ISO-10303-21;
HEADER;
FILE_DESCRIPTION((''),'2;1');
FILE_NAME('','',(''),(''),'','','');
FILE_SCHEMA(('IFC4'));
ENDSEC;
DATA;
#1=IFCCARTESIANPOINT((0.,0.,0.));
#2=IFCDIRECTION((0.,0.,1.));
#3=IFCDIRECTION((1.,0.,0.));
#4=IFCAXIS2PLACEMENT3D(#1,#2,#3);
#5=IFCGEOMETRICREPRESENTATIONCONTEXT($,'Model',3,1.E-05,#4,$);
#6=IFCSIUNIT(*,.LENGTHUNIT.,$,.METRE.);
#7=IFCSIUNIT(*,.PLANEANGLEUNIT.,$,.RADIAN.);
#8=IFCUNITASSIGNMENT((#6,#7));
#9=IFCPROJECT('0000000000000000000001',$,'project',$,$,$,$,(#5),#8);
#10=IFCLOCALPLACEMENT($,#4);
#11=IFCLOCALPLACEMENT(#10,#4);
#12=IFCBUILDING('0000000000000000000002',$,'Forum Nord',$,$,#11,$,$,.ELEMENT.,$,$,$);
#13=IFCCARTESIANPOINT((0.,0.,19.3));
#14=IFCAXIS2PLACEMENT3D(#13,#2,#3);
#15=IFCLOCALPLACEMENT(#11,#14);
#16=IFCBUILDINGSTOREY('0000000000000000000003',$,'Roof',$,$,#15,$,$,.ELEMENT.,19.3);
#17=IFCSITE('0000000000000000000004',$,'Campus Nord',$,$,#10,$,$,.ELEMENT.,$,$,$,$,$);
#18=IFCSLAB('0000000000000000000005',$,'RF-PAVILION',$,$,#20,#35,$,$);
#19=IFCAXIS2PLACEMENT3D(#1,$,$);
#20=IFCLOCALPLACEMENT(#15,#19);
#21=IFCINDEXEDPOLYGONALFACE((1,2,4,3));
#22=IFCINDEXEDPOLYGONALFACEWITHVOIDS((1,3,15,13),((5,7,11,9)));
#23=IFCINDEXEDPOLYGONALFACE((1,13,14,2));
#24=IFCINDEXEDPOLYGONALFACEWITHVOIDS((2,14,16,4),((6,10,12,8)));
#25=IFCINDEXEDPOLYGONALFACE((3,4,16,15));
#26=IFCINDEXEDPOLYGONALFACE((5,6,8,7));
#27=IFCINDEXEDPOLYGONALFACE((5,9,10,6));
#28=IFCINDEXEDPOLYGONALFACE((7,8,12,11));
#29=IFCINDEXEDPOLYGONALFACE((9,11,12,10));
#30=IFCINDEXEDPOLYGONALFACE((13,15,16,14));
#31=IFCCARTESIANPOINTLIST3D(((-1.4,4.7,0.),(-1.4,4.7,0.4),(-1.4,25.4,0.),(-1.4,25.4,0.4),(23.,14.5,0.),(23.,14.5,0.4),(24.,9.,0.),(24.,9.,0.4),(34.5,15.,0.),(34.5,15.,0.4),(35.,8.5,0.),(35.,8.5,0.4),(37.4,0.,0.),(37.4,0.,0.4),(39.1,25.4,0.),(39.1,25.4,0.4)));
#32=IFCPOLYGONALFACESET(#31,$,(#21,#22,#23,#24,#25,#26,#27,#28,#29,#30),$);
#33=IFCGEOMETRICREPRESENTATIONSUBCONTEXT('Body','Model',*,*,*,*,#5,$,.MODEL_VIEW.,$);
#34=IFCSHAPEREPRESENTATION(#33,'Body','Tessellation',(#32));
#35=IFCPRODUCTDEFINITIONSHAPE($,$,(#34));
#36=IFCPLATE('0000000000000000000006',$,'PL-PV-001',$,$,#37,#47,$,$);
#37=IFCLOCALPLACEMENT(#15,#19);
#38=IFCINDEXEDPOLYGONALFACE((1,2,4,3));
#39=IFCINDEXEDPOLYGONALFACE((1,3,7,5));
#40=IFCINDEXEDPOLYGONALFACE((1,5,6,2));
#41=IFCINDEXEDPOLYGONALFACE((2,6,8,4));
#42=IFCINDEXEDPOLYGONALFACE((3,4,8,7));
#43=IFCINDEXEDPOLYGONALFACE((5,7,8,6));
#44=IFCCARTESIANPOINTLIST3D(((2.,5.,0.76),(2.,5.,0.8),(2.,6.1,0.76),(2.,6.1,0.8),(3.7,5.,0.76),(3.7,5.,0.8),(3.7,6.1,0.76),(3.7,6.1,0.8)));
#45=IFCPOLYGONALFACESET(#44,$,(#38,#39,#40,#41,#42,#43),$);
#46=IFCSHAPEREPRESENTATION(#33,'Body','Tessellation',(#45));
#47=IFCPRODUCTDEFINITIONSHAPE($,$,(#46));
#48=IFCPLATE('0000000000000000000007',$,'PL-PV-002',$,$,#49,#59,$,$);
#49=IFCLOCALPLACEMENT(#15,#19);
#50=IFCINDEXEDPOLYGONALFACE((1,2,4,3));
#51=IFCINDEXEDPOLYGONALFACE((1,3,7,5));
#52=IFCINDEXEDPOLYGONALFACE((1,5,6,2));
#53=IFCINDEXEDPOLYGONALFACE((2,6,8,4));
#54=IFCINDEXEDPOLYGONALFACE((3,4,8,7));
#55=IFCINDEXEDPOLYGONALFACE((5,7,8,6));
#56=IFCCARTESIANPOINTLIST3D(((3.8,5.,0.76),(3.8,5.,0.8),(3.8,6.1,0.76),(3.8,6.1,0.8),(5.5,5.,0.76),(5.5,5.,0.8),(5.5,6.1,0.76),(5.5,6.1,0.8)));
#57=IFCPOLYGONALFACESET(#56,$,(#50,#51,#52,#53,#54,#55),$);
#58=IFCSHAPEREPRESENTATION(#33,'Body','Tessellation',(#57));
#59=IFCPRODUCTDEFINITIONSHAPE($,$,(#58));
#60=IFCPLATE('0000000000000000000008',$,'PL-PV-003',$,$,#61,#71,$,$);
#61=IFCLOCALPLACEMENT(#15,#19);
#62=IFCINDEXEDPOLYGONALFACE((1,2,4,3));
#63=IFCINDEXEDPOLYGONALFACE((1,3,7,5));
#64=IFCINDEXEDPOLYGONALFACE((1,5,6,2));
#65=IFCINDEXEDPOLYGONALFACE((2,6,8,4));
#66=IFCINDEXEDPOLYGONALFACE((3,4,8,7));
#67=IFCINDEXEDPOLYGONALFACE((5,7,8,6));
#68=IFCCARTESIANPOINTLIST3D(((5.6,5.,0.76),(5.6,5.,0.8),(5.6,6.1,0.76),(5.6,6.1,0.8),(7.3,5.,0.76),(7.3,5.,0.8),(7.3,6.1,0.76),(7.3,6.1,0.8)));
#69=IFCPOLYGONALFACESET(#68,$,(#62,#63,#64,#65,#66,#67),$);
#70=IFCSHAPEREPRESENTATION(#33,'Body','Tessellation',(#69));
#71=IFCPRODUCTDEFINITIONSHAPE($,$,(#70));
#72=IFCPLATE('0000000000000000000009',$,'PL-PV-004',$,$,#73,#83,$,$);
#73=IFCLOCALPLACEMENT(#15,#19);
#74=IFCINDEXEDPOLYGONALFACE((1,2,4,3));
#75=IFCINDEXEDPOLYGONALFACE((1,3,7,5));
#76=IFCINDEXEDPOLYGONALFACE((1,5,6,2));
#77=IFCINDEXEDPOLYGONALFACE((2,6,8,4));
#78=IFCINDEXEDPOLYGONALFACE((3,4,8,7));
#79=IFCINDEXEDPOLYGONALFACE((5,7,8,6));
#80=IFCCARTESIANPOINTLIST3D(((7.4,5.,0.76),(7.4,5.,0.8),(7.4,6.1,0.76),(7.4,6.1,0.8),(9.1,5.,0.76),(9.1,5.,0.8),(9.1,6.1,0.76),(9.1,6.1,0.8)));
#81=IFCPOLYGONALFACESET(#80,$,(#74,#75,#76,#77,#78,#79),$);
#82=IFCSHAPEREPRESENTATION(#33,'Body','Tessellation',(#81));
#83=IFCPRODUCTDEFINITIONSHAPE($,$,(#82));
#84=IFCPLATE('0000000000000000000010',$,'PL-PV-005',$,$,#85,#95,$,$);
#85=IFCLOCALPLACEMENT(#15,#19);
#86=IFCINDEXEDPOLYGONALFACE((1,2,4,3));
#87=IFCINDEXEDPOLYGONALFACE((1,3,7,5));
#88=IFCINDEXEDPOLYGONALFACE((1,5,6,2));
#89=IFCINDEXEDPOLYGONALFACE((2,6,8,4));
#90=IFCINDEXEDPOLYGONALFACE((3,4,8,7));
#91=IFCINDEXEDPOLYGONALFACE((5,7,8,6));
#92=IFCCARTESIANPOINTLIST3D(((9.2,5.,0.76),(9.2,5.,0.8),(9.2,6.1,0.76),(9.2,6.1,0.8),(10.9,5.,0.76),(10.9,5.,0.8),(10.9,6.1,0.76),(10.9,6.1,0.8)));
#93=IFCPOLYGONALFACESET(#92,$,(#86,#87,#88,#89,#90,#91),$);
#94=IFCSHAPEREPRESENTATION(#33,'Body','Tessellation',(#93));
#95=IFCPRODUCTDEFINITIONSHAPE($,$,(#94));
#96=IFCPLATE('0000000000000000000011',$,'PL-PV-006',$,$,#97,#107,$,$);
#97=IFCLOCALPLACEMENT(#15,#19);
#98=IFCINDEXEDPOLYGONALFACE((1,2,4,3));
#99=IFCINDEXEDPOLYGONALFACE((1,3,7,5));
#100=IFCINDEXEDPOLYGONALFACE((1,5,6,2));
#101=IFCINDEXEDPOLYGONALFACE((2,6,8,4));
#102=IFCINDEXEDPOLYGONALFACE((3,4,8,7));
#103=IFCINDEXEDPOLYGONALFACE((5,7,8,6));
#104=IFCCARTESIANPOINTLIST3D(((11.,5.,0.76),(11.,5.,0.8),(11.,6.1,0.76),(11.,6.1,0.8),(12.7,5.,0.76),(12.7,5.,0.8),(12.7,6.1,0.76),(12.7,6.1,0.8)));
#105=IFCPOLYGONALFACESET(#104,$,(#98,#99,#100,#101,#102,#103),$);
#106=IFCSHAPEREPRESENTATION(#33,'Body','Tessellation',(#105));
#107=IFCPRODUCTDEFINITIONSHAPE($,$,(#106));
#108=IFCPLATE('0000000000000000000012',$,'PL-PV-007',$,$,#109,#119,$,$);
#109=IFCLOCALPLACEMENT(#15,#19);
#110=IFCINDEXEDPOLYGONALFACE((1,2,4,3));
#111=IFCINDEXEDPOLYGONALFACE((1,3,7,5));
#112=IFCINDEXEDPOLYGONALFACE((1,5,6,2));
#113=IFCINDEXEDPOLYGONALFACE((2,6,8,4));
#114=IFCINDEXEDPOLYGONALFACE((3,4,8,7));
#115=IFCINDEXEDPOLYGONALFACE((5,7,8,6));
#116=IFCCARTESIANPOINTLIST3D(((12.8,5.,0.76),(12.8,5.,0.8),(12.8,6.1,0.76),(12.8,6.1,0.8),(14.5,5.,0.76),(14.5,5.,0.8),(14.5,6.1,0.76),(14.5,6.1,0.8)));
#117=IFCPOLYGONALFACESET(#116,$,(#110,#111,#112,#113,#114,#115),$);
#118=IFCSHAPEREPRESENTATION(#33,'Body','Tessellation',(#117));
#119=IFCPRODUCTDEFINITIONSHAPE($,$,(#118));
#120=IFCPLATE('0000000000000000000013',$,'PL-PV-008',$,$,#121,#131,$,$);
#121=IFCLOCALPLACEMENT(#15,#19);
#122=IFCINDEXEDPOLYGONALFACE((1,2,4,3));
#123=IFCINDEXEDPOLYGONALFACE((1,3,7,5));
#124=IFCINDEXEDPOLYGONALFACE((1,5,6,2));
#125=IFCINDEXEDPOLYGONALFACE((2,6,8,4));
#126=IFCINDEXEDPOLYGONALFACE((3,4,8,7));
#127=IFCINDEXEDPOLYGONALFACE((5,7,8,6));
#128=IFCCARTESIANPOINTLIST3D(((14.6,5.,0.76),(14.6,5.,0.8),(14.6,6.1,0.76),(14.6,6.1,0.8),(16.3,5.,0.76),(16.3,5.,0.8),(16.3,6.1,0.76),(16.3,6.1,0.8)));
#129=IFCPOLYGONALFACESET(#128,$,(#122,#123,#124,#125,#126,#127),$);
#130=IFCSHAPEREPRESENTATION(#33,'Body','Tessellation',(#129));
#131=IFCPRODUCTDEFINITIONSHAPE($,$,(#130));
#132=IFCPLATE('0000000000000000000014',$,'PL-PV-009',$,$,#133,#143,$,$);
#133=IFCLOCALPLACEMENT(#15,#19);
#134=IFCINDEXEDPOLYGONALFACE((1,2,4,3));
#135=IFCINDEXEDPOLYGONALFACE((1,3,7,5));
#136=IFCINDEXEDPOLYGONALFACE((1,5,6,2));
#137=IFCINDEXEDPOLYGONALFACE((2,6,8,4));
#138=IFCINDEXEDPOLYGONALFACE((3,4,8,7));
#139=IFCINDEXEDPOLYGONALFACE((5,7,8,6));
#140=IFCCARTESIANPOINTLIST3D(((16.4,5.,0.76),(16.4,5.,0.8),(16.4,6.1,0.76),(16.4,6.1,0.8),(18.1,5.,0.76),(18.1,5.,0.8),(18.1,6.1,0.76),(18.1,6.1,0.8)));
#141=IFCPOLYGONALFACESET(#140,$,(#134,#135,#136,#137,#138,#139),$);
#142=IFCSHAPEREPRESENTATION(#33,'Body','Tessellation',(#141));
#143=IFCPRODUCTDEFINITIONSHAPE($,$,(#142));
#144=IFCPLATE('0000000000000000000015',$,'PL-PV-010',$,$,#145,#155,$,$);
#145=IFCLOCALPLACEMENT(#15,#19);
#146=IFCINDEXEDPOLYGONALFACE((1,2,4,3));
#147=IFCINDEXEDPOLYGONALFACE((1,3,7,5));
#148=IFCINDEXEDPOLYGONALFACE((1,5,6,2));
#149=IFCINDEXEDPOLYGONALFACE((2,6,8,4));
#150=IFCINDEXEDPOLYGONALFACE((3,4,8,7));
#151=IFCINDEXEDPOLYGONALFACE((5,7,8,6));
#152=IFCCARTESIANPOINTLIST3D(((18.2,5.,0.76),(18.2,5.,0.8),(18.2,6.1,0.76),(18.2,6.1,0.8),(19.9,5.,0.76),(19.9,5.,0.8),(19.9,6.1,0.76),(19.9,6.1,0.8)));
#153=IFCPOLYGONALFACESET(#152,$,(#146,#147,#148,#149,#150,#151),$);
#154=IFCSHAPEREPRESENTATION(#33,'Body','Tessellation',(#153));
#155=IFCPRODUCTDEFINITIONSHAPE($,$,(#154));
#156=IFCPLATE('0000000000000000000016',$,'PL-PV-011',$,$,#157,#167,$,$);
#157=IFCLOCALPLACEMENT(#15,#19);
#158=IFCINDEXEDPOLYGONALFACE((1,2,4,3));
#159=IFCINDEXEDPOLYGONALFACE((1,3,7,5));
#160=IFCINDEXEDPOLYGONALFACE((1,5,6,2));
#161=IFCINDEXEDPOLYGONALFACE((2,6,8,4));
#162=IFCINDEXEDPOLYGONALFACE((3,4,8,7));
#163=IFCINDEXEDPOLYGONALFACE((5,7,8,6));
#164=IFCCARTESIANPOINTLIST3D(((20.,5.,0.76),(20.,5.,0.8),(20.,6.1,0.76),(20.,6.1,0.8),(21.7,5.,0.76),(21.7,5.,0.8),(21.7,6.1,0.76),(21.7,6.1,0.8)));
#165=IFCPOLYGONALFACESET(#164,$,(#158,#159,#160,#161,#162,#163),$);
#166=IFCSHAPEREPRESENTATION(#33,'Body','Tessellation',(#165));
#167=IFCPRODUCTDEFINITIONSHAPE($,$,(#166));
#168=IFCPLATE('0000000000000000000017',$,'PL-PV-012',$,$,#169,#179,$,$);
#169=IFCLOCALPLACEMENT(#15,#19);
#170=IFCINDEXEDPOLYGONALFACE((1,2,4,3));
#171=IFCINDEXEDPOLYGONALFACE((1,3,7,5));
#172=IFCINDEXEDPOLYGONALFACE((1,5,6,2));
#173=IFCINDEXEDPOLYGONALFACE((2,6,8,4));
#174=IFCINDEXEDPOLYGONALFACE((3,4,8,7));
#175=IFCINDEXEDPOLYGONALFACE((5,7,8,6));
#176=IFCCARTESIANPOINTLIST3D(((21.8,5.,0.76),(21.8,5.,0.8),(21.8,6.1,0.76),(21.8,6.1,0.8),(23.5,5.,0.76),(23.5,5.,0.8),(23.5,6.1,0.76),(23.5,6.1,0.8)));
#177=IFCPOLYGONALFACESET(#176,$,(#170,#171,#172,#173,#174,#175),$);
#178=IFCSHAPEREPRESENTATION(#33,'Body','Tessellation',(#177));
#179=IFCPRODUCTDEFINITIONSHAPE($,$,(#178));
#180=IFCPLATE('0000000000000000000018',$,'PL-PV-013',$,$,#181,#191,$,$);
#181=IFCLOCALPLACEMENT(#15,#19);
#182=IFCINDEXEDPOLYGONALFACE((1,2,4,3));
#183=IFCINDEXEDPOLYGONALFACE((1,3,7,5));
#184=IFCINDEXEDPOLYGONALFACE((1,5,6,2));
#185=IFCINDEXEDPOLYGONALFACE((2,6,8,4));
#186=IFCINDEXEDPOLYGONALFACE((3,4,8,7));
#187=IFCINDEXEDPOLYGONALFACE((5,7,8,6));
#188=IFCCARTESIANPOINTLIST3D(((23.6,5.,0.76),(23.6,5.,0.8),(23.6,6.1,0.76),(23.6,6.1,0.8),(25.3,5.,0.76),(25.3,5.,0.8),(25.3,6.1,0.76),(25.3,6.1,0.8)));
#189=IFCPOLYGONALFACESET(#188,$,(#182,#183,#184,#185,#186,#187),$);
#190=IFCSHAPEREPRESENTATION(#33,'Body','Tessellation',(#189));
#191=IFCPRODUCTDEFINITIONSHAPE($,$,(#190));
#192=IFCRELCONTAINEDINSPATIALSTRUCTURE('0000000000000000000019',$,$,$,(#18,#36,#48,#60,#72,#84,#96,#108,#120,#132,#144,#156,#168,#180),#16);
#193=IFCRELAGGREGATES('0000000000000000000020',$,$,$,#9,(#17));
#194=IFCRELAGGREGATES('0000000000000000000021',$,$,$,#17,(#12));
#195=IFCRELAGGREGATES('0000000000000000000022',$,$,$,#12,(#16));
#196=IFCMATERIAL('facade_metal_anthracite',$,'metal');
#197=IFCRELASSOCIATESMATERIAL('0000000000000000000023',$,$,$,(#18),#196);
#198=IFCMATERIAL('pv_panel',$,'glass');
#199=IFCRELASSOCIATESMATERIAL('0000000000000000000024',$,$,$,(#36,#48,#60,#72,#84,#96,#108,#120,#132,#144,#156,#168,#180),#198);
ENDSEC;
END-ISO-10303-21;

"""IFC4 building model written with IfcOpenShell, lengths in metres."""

from ifc_helpers import new_model, si_unit, frame, origin_with_axes, place, context, subcontext, project, spatial, polyline, outline, extrude, material, element, save


model = new_model("IFC4")

# Units and contexts
model_context = context("Model", 3, precision=1e-05, world=origin_with_axes())
body_context = subcontext(model_context, "Body", "Model", "MODEL_VIEW")
ifc_project = project(units=[si_unit("LENGTHUNIT", "METRE"), si_unit("PLANEANGLEUNIT", "RADIAN")], contexts=[model_context])

# Site, building, storey
site_placement = place(None, origin_with_axes())
site = spatial("IfcSite", under=ifc_project, at=site_placement, Name="Campus Nord", CompositionType="ELEMENT")
building_placement = place(site_placement, origin_with_axes())
building = spatial("IfcBuilding", under=site, at=building_placement, Name="Forum Nord", CompositionType="ELEMENT")
storey_placement = place(building_placement, frame((0.0, 0.0, 19.3), z_axis=(0.0, 0.0, 1.0), x_axis=(1.0, 0.0, 0.0)))
storey = spatial("IfcBuildingStorey", under=building, at=storey_placement, Name="Roof", CompositionType="ELEMENT", Elevation=19.3)

# Slab
ifc_material_1 = material(Name="facade_metal_anthracite", Category="metal")
slab_placement = place(storey_placement, frame((0.0, 0.0, 0.4), z_axis=(0.0, 0.0, 1.0), x_axis=(1.0, 0.0, 0.0)))
element("IfcSlab", 1, at=slab_placement, inside=storey, material=ifc_material_1, Name="RF-PAVILION", context=body_context, shape_type="SweptSolid", body=[
    extrude(outline(polyline([(-1.4, 4.7), (37.4, 0.0), (39.1, 25.4), (-1.4, 25.4), (-1.4, 4.7)]), holes=[polyline([(24.0, 9.0), (35.0, 8.5), (34.5, 15.0), (23.0, 14.5), (24.0, 9.0)])]), frame((0.0, 0.0, -0.4), z_axis=(0.0, 0.0, 1.0), x_axis=(1.0, 0.0, 0.0)), (0.0, 0.0, 1.0), 0.4),
])

# Plates
ifc_material_2 = material(Name="pv_panel", Category="glass")
plate_1_placement = place(storey_placement, frame((0.0, 0.0, 0.8), z_axis=(0.0, 0.0, 1.0), x_axis=(1.0, 0.0, 0.0)))
element("IfcPlate", 2, at=plate_1_placement, inside=storey, material=ifc_material_2, Name="PL-PV-001", context=body_context, shape_type="SweptSolid", body=[
    extrude(outline(polyline([(2.0, 5.0), (3.7, 5.0), (3.7, 6.1), (2.0, 6.1), (2.0, 5.0)])), frame((0.0, 0.0, -0.04), z_axis=(0.0, 0.0, 1.0), x_axis=(1.0, 0.0, 0.0)), (0.0, 0.0, 1.0), 0.04),
])
plate_2_placement = place(storey_placement, frame((0.0, 0.0, 0.8), z_axis=(0.0, 0.0, 1.0), x_axis=(1.0, 0.0, 0.0)))
element("IfcPlate", 3, at=plate_2_placement, inside=storey, material=ifc_material_2, Name="PL-PV-002", context=body_context, shape_type="SweptSolid", body=[
    extrude(outline(polyline([(3.8, 5.0), (5.5, 5.0), (5.5, 6.1), (3.8, 6.1), (3.8, 5.0)])), frame((0.0, 0.0, -0.04), z_axis=(0.0, 0.0, 1.0), x_axis=(1.0, 0.0, 0.0)), (0.0, 0.0, 1.0), 0.04),
])
plate_3_placement = place(storey_placement, frame((0.0, 0.0, 0.8), z_axis=(0.0, 0.0, 1.0), x_axis=(1.0, 0.0, 0.0)))
element("IfcPlate", 4, at=plate_3_placement, inside=storey, material=ifc_material_2, Name="PL-PV-003", context=body_context, shape_type="SweptSolid", body=[
    extrude(outline(polyline([(5.6, 5.0), (7.3, 5.0), (7.3, 6.1), (5.6, 6.1), (5.6, 5.0)])), frame((0.0, 0.0, -0.04), z_axis=(0.0, 0.0, 1.0), x_axis=(1.0, 0.0, 0.0)), (0.0, 0.0, 1.0), 0.04),
])
plate_4_placement = place(storey_placement, frame((0.0, 0.0, 0.8), z_axis=(0.0, 0.0, 1.0), x_axis=(1.0, 0.0, 0.0)))
element("IfcPlate", 5, at=plate_4_placement, inside=storey, material=ifc_material_2, Name="PL-PV-004", context=body_context, shape_type="SweptSolid", body=[
    extrude(outline(polyline([(7.4, 5.0), (9.1, 5.0), (9.1, 6.1), (7.4, 6.1), (7.4, 5.0)])), frame((0.0, 0.0, -0.04), z_axis=(0.0, 0.0, 1.0), x_axis=(1.0, 0.0, 0.0)), (0.0, 0.0, 1.0), 0.04),
])
plate_5_placement = place(storey_placement, frame((0.0, 0.0, 0.8), z_axis=(0.0, 0.0, 1.0), x_axis=(1.0, 0.0, 0.0)))
element("IfcPlate", 6, at=plate_5_placement, inside=storey, material=ifc_material_2, Name="PL-PV-005", context=body_context, shape_type="SweptSolid", body=[
    extrude(outline(polyline([(9.2, 5.0), (10.9, 5.0), (10.9, 6.1), (9.2, 6.1), (9.2, 5.0)])), frame((0.0, 0.0, -0.04), z_axis=(0.0, 0.0, 1.0), x_axis=(1.0, 0.0, 0.0)), (0.0, 0.0, 1.0), 0.04),
])
plate_6_placement = place(storey_placement, frame((0.0, 0.0, 0.8), z_axis=(0.0, 0.0, 1.0), x_axis=(1.0, 0.0, 0.0)))
element("IfcPlate", 7, at=plate_6_placement, inside=storey, material=ifc_material_2, Name="PL-PV-006", context=body_context, shape_type="SweptSolid", body=[
    extrude(outline(polyline([(11.0, 5.0), (12.7, 5.0), (12.7, 6.1), (11.0, 6.1), (11.0, 5.0)])), frame((0.0, 0.0, -0.04), z_axis=(0.0, 0.0, 1.0), x_axis=(1.0, 0.0, 0.0)), (0.0, 0.0, 1.0), 0.04),
])
plate_7_placement = place(storey_placement, frame((0.0, 0.0, 0.8), z_axis=(0.0, 0.0, 1.0), x_axis=(1.0, 0.0, 0.0)))
element("IfcPlate", 8, at=plate_7_placement, inside=storey, material=ifc_material_2, Name="PL-PV-007", context=body_context, shape_type="SweptSolid", body=[
    extrude(outline(polyline([(12.8, 5.0), (14.5, 5.0), (14.5, 6.1), (12.8, 6.1), (12.8, 5.0)])), frame((0.0, 0.0, -0.04), z_axis=(0.0, 0.0, 1.0), x_axis=(1.0, 0.0, 0.0)), (0.0, 0.0, 1.0), 0.04),
])
plate_8_placement = place(storey_placement, frame((0.0, 0.0, 0.8), z_axis=(0.0, 0.0, 1.0), x_axis=(1.0, 0.0, 0.0)))
element("IfcPlate", 9, at=plate_8_placement, inside=storey, material=ifc_material_2, Name="PL-PV-008", context=body_context, shape_type="SweptSolid", body=[
    extrude(outline(polyline([(14.6, 5.0), (16.3, 5.0), (16.3, 6.1), (14.6, 6.1), (14.6, 5.0)])), frame((0.0, 0.0, -0.04), z_axis=(0.0, 0.0, 1.0), x_axis=(1.0, 0.0, 0.0)), (0.0, 0.0, 1.0), 0.04),
])
plate_9_placement = place(storey_placement, frame((0.0, 0.0, 0.8), z_axis=(0.0, 0.0, 1.0), x_axis=(1.0, 0.0, 0.0)))
element("IfcPlate", 10, at=plate_9_placement, inside=storey, material=ifc_material_2, Name="PL-PV-009", context=body_context, shape_type="SweptSolid", body=[
    extrude(outline(polyline([(16.4, 5.0), (18.1, 5.0), (18.1, 6.1), (16.4, 6.1), (16.4, 5.0)])), frame((0.0, 0.0, -0.04), z_axis=(0.0, 0.0, 1.0), x_axis=(1.0, 0.0, 0.0)), (0.0, 0.0, 1.0), 0.04),
])
plate_10_placement = place(storey_placement, frame((0.0, 0.0, 0.8), z_axis=(0.0, 0.0, 1.0), x_axis=(1.0, 0.0, 0.0)))
element("IfcPlate", 11, at=plate_10_placement, inside=storey, material=ifc_material_2, Name="PL-PV-010", context=body_context, shape_type="SweptSolid", body=[
    extrude(outline(polyline([(18.2, 5.0), (19.9, 5.0), (19.9, 6.1), (18.2, 6.1), (18.2, 5.0)])), frame((0.0, 0.0, -0.04), z_axis=(0.0, 0.0, 1.0), x_axis=(1.0, 0.0, 0.0)), (0.0, 0.0, 1.0), 0.04),
])
plate_11_placement = place(storey_placement, frame((0.0, 0.0, 0.8), z_axis=(0.0, 0.0, 1.0), x_axis=(1.0, 0.0, 0.0)))
element("IfcPlate", 12, at=plate_11_placement, inside=storey, material=ifc_material_2, Name="PL-PV-011", context=body_context, shape_type="SweptSolid", body=[
    extrude(outline(polyline([(20.0, 5.0), (21.7, 5.0), (21.7, 6.1), (20.0, 6.1), (20.0, 5.0)])), frame((0.0, 0.0, -0.04), z_axis=(0.0, 0.0, 1.0), x_axis=(1.0, 0.0, 0.0)), (0.0, 0.0, 1.0), 0.04),
])
plate_12_placement = place(storey_placement, frame((0.0, 0.0, 0.8), z_axis=(0.0, 0.0, 1.0), x_axis=(1.0, 0.0, 0.0)))
element("IfcPlate", 13, at=plate_12_placement, inside=storey, material=ifc_material_2, Name="PL-PV-012", context=body_context, shape_type="SweptSolid", body=[
    extrude(outline(polyline([(21.8, 5.0), (23.5, 5.0), (23.5, 6.1), (21.8, 6.1), (21.8, 5.0)])), frame((0.0, 0.0, -0.04), z_axis=(0.0, 0.0, 1.0), x_axis=(1.0, 0.0, 0.0)), (0.0, 0.0, 1.0), 0.04),
])
plate_13_placement = place(storey_placement, frame((0.0, 0.0, 0.8), z_axis=(0.0, 0.0, 1.0), x_axis=(1.0, 0.0, 0.0)))
element("IfcPlate", 14, at=plate_13_placement, inside=storey, material=ifc_material_2, Name="PL-PV-013", context=body_context, shape_type="SweptSolid", body=[
    extrude(outline(polyline([(23.6, 5.0), (25.3, 5.0), (25.3, 6.1), (23.6, 6.1), (23.6, 5.0)])), frame((0.0, 0.0, -0.04), z_axis=(0.0, 0.0, 1.0), x_axis=(1.0, 0.0, 0.0)), (0.0, 0.0, 1.0), 0.04),
])

save(model, "model.ifc")
